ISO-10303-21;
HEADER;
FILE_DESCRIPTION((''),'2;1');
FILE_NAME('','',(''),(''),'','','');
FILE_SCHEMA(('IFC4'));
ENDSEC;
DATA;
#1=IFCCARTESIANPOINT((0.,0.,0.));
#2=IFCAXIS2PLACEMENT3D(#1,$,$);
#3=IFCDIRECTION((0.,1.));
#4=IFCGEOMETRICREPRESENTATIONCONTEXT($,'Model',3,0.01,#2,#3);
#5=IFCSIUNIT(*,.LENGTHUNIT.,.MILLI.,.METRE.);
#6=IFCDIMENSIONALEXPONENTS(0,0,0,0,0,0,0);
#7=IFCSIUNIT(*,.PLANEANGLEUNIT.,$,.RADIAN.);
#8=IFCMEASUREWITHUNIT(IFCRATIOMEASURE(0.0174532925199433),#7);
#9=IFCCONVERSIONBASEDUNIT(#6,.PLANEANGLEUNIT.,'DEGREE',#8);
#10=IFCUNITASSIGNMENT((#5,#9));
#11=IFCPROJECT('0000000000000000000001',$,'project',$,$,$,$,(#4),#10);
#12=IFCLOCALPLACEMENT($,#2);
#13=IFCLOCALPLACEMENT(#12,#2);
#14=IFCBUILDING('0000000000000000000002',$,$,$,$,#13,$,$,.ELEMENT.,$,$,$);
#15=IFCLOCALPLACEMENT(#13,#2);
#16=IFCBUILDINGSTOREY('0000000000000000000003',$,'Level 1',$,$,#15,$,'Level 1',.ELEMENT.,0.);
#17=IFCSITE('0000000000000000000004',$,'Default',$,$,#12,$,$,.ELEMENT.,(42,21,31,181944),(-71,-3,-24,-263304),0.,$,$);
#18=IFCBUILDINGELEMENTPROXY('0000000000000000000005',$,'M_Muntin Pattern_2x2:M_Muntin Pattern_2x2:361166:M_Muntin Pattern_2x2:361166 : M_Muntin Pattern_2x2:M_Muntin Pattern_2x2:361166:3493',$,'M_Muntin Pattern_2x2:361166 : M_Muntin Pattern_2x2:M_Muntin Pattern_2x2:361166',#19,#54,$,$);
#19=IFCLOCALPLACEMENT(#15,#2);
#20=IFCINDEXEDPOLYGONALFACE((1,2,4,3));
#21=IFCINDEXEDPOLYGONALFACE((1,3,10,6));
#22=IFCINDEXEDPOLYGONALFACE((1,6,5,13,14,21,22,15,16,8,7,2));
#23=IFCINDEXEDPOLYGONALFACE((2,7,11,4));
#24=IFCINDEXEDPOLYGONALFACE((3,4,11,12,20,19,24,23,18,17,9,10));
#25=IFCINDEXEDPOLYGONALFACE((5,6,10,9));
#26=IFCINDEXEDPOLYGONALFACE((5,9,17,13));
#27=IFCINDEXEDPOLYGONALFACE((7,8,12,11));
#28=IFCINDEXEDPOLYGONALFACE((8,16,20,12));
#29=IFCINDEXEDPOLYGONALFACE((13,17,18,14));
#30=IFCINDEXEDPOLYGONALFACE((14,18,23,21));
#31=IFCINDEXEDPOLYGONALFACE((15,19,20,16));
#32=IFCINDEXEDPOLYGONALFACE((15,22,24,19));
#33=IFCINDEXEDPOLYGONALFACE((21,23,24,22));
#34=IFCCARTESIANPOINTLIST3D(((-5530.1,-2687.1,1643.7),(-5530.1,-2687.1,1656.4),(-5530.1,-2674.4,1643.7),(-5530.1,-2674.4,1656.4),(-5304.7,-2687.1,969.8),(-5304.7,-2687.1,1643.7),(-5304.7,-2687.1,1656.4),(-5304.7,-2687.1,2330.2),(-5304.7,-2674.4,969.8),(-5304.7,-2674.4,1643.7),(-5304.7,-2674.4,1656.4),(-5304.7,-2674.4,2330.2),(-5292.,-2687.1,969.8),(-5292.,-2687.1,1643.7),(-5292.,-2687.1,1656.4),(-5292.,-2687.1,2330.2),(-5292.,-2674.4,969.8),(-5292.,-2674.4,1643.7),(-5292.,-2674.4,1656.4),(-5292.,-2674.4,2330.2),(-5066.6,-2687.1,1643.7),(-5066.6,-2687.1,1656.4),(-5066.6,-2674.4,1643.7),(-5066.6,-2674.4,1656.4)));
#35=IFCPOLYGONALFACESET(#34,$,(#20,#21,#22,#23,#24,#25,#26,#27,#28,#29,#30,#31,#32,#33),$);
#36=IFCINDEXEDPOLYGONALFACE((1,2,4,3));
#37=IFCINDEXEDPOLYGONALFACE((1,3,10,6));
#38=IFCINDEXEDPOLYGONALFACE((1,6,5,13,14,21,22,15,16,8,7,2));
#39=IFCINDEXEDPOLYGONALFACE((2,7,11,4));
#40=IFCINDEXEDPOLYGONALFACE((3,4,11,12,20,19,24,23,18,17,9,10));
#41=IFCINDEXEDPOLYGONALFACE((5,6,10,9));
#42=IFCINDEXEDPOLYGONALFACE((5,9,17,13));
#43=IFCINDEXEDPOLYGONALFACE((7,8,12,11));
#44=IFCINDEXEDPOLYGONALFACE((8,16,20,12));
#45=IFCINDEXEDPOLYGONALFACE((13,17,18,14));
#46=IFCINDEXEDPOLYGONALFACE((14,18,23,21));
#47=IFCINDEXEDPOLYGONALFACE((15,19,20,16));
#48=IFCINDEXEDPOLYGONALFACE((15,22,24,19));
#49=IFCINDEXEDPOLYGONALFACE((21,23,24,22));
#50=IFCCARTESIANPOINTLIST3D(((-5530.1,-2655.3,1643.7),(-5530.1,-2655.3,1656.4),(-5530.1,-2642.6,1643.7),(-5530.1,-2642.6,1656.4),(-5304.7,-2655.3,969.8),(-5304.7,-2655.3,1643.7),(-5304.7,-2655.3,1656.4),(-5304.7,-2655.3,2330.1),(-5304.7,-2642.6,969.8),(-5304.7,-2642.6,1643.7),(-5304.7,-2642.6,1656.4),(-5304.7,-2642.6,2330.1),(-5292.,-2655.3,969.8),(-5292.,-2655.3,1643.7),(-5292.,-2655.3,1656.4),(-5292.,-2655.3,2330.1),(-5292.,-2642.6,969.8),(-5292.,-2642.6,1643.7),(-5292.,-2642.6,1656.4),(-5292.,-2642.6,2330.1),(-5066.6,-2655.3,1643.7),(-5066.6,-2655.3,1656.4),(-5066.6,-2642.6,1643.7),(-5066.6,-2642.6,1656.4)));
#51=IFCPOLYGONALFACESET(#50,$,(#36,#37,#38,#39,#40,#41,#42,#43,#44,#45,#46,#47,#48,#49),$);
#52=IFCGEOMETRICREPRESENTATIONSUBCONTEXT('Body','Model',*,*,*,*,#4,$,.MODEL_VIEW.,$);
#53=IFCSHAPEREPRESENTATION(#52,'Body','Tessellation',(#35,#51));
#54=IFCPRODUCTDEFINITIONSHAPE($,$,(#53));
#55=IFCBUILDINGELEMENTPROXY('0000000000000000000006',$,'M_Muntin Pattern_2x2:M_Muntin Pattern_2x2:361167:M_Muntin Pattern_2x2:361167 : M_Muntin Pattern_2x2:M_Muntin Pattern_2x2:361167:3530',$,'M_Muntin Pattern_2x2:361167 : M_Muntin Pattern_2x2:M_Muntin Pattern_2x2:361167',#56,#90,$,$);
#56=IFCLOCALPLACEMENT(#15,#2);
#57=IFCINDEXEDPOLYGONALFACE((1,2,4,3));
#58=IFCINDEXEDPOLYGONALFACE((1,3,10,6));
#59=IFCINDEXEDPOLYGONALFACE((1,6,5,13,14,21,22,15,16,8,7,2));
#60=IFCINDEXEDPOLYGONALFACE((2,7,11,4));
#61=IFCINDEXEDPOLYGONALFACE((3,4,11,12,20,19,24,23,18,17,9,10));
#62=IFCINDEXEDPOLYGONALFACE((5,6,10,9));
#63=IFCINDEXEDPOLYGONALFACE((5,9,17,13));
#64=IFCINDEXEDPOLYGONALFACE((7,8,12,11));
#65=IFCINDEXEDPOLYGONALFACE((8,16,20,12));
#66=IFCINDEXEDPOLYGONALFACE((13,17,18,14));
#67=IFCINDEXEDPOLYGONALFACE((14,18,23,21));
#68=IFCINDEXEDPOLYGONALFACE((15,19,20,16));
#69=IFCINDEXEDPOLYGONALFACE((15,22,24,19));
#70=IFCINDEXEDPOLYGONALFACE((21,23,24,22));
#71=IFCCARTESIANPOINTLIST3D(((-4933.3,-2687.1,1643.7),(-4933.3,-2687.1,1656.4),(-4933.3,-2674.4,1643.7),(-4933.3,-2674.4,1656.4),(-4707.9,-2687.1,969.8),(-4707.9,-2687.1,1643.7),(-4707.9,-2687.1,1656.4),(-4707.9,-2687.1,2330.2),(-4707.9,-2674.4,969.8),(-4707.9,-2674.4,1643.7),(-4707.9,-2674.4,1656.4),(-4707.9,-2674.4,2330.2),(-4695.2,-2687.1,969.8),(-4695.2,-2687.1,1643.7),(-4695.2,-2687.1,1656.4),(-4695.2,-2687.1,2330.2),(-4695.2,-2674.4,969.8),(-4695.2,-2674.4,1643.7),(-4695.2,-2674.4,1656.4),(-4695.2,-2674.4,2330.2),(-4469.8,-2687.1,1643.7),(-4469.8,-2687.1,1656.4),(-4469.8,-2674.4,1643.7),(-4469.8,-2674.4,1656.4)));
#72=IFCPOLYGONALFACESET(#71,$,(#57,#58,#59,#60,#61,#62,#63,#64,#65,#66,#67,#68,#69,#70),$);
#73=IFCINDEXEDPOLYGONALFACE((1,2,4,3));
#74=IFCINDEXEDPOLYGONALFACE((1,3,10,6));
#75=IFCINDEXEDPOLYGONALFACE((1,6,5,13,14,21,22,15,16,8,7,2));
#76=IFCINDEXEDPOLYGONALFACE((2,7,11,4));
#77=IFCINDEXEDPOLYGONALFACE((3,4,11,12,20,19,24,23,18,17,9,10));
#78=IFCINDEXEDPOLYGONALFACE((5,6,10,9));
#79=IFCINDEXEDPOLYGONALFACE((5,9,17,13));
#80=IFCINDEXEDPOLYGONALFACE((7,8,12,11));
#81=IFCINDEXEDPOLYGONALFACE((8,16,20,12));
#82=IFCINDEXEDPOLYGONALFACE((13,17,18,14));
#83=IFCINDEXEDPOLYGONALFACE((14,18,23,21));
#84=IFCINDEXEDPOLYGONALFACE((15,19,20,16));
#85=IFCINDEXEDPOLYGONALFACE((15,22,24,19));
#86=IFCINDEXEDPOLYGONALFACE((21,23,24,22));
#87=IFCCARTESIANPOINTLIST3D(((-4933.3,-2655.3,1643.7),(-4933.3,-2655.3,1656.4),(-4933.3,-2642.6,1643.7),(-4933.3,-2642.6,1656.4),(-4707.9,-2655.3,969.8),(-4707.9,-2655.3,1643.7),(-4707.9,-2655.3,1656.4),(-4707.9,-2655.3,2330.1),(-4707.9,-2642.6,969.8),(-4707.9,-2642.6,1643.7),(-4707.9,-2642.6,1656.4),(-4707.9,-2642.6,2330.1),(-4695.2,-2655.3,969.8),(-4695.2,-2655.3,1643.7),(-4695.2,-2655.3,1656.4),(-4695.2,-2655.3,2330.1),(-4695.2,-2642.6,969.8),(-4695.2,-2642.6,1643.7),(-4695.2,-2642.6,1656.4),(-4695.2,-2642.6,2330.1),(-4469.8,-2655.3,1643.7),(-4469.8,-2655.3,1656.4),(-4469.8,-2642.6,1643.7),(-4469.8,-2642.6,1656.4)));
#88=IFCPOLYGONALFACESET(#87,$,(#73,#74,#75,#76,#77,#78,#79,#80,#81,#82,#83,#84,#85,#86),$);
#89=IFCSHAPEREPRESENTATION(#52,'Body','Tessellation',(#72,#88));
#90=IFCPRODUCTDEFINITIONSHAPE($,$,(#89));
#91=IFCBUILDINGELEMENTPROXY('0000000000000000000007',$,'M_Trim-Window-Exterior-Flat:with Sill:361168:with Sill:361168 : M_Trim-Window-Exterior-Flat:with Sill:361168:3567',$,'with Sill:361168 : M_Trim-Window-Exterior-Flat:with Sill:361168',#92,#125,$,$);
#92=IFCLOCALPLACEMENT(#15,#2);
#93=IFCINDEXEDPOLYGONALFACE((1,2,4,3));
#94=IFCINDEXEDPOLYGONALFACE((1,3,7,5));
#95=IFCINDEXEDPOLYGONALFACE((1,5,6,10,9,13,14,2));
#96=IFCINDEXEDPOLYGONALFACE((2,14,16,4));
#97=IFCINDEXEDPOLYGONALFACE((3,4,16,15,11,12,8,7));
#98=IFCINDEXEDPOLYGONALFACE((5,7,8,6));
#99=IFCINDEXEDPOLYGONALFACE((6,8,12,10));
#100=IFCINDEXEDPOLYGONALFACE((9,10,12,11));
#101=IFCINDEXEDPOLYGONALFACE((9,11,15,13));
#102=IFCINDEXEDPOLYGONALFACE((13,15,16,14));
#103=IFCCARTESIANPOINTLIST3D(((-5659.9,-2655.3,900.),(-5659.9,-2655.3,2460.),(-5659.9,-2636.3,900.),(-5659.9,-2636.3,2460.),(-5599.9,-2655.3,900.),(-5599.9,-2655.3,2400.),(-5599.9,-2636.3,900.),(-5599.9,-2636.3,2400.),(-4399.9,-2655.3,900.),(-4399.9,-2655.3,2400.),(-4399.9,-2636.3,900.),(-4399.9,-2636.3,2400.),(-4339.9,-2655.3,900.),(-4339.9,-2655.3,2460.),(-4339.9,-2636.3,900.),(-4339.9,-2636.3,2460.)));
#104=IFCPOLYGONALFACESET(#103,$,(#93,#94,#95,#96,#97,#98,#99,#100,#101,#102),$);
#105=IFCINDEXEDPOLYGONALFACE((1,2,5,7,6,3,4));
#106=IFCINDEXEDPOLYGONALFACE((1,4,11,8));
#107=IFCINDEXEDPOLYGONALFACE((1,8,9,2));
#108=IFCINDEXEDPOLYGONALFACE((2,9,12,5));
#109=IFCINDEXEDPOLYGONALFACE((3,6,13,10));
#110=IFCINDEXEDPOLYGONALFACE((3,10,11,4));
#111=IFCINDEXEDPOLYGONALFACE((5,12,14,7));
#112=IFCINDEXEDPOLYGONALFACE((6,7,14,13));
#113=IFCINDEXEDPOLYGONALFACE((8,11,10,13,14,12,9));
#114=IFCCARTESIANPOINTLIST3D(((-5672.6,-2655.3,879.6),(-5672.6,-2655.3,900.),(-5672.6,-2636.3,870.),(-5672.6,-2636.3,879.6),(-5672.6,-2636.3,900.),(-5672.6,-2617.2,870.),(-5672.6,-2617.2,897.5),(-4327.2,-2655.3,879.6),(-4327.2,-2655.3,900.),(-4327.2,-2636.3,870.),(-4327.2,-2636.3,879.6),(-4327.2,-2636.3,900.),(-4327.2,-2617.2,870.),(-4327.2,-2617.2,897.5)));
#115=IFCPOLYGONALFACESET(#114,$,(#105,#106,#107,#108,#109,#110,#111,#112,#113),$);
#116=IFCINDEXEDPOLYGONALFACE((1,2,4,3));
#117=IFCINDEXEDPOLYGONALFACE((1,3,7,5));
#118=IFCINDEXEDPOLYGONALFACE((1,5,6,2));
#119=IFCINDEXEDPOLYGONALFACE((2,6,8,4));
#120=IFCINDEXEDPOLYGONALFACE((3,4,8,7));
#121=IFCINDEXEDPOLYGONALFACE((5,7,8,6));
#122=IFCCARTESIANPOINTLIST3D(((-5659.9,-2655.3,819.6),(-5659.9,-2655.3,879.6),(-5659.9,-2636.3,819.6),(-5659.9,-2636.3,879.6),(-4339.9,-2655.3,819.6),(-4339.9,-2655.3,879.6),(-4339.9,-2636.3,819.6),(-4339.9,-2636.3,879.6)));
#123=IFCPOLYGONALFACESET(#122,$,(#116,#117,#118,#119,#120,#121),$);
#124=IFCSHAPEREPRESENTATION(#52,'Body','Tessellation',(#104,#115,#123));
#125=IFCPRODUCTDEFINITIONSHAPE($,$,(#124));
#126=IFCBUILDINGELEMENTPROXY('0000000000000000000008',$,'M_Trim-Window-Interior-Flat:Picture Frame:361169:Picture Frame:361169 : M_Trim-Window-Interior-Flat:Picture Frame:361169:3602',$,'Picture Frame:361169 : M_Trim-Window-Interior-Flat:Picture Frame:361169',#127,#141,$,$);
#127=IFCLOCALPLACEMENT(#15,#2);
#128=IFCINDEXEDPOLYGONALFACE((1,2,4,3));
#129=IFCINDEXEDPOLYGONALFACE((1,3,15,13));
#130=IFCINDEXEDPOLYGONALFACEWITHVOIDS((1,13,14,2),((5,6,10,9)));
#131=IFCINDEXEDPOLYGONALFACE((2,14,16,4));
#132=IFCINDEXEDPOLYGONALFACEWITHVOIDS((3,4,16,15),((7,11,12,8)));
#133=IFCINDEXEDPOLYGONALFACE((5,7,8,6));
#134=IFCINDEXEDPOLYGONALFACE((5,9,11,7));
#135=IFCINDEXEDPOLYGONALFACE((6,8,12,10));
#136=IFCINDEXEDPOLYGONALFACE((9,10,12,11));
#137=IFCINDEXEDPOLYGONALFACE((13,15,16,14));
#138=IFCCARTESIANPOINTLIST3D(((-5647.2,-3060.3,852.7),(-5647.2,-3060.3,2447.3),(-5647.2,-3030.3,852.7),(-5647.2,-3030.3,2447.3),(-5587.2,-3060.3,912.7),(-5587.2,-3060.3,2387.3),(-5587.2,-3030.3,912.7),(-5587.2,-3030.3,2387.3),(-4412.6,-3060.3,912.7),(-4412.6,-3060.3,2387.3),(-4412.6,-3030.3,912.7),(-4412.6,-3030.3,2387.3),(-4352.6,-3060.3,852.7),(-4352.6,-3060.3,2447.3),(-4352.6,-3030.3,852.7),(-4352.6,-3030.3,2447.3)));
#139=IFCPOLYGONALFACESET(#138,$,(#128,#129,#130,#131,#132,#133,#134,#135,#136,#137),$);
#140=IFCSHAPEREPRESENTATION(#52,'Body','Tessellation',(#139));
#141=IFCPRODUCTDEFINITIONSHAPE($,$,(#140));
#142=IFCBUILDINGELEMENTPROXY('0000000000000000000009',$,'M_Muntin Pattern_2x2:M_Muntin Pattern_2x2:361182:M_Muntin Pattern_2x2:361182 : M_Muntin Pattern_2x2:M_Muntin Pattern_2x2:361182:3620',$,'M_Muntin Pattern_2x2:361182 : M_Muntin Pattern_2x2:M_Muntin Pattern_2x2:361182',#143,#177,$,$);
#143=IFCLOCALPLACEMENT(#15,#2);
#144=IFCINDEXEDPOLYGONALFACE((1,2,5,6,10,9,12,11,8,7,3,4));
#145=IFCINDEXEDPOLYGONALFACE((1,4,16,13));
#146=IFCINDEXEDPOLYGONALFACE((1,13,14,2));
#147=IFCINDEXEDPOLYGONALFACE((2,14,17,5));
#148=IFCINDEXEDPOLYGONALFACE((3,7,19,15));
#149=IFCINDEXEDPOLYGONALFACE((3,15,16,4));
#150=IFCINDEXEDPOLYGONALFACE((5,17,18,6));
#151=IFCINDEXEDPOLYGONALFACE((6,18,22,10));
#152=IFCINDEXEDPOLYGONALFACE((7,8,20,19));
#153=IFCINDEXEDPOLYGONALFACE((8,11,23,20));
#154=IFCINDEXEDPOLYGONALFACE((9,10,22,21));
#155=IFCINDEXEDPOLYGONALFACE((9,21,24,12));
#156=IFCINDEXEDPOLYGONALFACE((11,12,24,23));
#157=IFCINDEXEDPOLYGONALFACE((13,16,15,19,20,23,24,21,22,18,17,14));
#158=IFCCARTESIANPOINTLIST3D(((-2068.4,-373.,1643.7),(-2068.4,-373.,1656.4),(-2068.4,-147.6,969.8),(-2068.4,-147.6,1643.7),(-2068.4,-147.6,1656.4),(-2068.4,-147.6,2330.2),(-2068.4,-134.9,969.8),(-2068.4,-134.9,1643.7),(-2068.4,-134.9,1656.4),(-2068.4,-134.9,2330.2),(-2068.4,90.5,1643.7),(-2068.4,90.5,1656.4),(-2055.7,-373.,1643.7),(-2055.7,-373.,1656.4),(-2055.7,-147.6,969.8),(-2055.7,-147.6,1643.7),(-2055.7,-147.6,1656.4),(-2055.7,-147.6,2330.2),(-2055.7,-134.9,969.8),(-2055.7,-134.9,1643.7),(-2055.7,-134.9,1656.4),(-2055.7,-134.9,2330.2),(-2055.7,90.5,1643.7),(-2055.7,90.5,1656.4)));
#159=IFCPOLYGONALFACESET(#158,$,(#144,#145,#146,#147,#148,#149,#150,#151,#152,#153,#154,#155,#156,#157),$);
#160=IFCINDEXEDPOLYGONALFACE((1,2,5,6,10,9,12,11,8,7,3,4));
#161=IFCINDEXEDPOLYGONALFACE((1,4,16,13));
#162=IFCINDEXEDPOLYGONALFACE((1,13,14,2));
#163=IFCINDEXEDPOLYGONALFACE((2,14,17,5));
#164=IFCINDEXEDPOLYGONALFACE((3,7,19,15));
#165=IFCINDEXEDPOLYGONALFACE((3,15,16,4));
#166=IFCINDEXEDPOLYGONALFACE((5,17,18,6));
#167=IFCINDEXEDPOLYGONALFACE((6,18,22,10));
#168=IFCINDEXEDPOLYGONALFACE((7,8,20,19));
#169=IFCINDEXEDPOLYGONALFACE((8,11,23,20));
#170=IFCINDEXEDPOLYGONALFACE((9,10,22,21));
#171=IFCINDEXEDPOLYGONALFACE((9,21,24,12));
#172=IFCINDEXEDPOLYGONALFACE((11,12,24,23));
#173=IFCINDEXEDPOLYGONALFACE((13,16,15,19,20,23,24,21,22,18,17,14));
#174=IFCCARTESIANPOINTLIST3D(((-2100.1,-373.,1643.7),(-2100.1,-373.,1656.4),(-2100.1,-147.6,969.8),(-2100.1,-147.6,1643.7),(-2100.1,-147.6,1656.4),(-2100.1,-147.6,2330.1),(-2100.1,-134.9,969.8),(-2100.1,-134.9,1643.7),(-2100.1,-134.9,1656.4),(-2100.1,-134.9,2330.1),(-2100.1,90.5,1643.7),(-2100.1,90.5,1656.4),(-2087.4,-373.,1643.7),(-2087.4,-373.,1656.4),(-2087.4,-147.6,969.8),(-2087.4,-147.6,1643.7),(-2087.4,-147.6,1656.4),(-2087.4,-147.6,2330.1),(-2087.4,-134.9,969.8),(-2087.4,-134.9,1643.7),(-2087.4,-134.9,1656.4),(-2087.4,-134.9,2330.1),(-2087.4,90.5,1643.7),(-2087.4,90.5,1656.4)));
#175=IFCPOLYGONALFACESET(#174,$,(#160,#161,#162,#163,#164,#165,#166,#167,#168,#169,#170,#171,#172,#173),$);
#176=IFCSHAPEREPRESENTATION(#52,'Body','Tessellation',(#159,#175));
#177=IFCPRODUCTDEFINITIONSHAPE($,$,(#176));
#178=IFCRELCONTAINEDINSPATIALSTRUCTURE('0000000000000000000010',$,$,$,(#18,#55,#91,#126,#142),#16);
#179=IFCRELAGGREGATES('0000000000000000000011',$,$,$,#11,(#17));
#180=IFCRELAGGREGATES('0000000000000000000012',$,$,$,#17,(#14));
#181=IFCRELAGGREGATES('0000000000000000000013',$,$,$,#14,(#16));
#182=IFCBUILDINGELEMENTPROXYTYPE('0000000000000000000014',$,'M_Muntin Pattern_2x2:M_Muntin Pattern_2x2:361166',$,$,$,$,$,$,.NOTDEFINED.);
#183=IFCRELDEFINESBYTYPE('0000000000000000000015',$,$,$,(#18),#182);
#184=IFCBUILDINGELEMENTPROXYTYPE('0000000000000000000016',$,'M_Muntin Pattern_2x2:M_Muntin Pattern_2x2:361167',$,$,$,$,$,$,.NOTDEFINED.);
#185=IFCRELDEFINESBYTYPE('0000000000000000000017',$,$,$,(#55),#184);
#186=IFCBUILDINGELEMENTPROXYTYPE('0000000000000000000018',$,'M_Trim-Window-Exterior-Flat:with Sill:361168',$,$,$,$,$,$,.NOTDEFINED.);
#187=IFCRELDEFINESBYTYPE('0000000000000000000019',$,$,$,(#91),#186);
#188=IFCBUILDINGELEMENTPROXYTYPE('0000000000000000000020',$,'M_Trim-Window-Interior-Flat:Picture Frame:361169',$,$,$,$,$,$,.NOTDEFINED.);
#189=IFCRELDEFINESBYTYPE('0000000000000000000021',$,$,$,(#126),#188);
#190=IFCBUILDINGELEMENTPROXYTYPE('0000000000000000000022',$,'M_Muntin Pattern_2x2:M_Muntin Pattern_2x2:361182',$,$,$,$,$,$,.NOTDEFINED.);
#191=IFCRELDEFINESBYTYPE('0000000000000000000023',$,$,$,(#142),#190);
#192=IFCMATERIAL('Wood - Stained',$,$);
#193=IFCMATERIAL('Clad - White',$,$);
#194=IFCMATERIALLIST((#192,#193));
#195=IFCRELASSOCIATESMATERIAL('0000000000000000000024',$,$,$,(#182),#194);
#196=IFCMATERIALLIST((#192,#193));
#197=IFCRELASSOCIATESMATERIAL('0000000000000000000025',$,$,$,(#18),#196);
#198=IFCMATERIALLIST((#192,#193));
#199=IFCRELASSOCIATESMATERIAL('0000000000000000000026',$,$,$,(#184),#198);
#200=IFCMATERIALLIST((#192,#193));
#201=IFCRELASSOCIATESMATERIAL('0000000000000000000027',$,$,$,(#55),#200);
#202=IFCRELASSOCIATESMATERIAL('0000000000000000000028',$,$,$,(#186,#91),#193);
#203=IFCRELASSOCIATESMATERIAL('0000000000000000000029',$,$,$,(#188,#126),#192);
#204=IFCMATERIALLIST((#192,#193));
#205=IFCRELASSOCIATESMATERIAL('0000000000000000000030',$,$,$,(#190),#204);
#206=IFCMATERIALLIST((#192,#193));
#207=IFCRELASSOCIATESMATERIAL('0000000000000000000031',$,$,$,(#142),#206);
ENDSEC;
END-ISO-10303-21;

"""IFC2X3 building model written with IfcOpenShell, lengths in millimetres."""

from ifc_helpers import new_model, entity, si_unit, converted_unit, direction, frame, frame_2d, origin, place, context, subcontext, project, spatial, polyline, rectangle, outline, extrude, source, transform, mapped, material, material_list, type_object, type_shapes, element, save


model = new_model("IFC2X3")

# Units and contexts
model_context = context("Model", 3, precision=0.01, world=origin(), true_north=direction((0.0, 1.0)))
body_context = subcontext(model_context, "Body", "Model", "MODEL_VIEW")
ifc_project = project(units=[si_unit("LENGTHUNIT", "METRE", prefix="MILLI"), converted_unit("PLANEANGLEUNIT", "DEGREE", entity("IfcRatioMeasure", 0.0174532925199433), si_unit("PLANEANGLEUNIT", "RADIAN"), dimensions=[0, 0, 0, 0, 0, 0, 0])], contexts=[model_context])

# Site, building, storey
site_placement = place(None, origin())
site = spatial("IfcSite", under=ifc_project, at=site_placement, Name="Default", CompositionType="ELEMENT", RefLatitude=(42, 21, 31, 181944), RefLongitude=(-71, -3, -24, -263304), RefElevation=0.0)
building_placement = place(site_placement, origin())
building = spatial("IfcBuilding", under=site, at=building_placement, CompositionType="ELEMENT")
storey_placement = place(building_placement, origin())
storey = spatial("IfcBuildingStorey", under=building, at=storey_placement, Name="Level 1", LongName="Level 1", CompositionType="ELEMENT", Elevation=0.0)

# Building element proxies
ifc_material_1 = material(Name="Wood - Stained")
ifc_material_2 = material(Name="Clad - White")
ifc_material_list_1 = material_list([ifc_material_1, ifc_material_2])
ifc_material_list_2 = material_list([ifc_material_1, ifc_material_2])
building_element_proxy_type_1 = type_object("IfcBuildingElementProxyType", Name="M_Muntin Pattern_2x2:M_Muntin Pattern_2x2:361166", PredefinedType="NOTDEFINED", material=ifc_material_list_2)
shared_shape_1 = source(origin(), body_context, "Body", "SweptSolid", [
    extrude(outline(polyline([(-6.4, -680.2), (6.3, -680.2), (6.3, -6.4), (231.7, -6.4), (231.7, 6.3), (6.3, 6.3), (6.3, 680.2), (-6.4, 680.2), (-6.4, 6.3), (-231.7, 6.3), (-231.7, -6.4), (-6.4, -6.4), (-6.4, -680.2)])), frame((-5298.4, -2687.1, 1650.0), z_axis=(0.0, 1.0, 0.0), x_axis=(1.0, 0.0, 0.0)), (0.0, 0.0, 1.0), 12.7),
    extrude(outline(polyline([(-6.4, -680.1), (6.3, -680.1), (6.3, -6.4), (231.7, -6.4), (231.7, 6.3), (6.3, 6.3), (6.3, 680.2), (-6.4, 680.2), (-6.4, 6.3), (-231.7, 6.3), (-231.7, -6.4), (-6.4, -6.4), (-6.4, -680.1)])), frame((-5298.4, -2655.3, 1650.0), z_axis=(0.0, 1.0, 0.0), x_axis=(1.0, 0.0, 0.0)), (0.0, 0.0, 1.0), 12.7),
])
type_shapes(building_element_proxy_type_1, [shared_shape_1])
proxy_1_placement = place(storey_placement, origin())
element("IfcBuildingElementProxy", 1, at=proxy_1_placement, inside=storey, type_object=building_element_proxy_type_1, material=ifc_material_list_1, Name="M_Muntin Pattern_2x2:M_Muntin Pattern_2x2:361166:M_Muntin Pattern_2x2:361166 : M_Muntin Pattern_2x2:M_Muntin Pattern_2x2:361166:3493", ObjectType="M_Muntin Pattern_2x2:361166 : M_Muntin Pattern_2x2:M_Muntin Pattern_2x2:361166", context=body_context, shape_type="MappedRepresentation", body=[
    mapped(shared_shape_1, transform((0.0, 0.0, 0.0), scale=1.0)),
])
ifc_material_list_3 = material_list([ifc_material_1, ifc_material_2])
ifc_material_list_4 = material_list([ifc_material_1, ifc_material_2])
building_element_proxy_type_2 = type_object("IfcBuildingElementProxyType", Name="M_Muntin Pattern_2x2:M_Muntin Pattern_2x2:361167", PredefinedType="NOTDEFINED", material=ifc_material_list_4)
shared_shape_2 = source(origin(), body_context, "Body", "SweptSolid", [
    extrude(outline(polyline([(-680.1, 6.4), (-680.1, -6.3), (-6.4, -6.3), (-6.4, -231.7), (6.3, -231.7), (6.3, -6.3), (680.2, -6.3), (680.2, 6.4), (6.3, 6.4), (6.3, 231.7), (-6.4, 231.7), (-6.4, 6.4), (-680.1, 6.4)])), frame((-4701.5, -2687.1, 1650.0), z_axis=(0.0, -1.0, 0.0), x_axis=(0.0, 0.0, -1.0)), (0.0, 0.0, -1.0), 12.7),
    extrude(outline(polyline([(-680.1, 6.4), (-680.1, -6.3), (-6.4, -6.3), (-6.4, -231.7), (6.3, -231.7), (6.3, -6.3), (680.2, -6.3), (680.2, 6.4), (6.3, 6.4), (6.3, 231.7), (-6.4, 231.7), (-6.4, 6.4), (-680.1, 6.4)])), frame((-4701.5, -2655.3, 1650.0), z_axis=(0.0, -1.0, 0.0), x_axis=(0.0, 0.0, -1.0)), (0.0, 0.0, -1.0), 12.7),
])
type_shapes(building_element_proxy_type_2, [shared_shape_2])
proxy_2_placement = place(storey_placement, origin())
element("IfcBuildingElementProxy", 2, at=proxy_2_placement, inside=storey, type_object=building_element_proxy_type_2, material=ifc_material_list_3, Name="M_Muntin Pattern_2x2:M_Muntin Pattern_2x2:361167:M_Muntin Pattern_2x2:361167 : M_Muntin Pattern_2x2:M_Muntin Pattern_2x2:361167:3530", ObjectType="M_Muntin Pattern_2x2:361167 : M_Muntin Pattern_2x2:M_Muntin Pattern_2x2:361167", context=body_context, shape_type="MappedRepresentation", body=[
    mapped(shared_shape_2, transform((0.0, 0.0, 0.0), scale=1.0)),
])
building_element_proxy_type_3 = type_object("IfcBuildingElementProxyType", Name="M_Trim-Window-Exterior-Flat:with Sill:361168", PredefinedType="NOTDEFINED", material=ifc_material_2)
shared_shape_3 = source(origin(), body_context, "Body", "SweptSolid", [
    extrude(outline(polyline([(-660.0, -765.0), (-600.0, -765.0), (-600.0, 735.0), (600.0, 735.0), (600.0, -765.0), (660.0, -765.0), (660.0, 795.0), (-660.0, 795.0), (-660.0, -765.0)])), frame((-4999.9, -2655.3, 1665.0), z_axis=(0.0, 1.0, 0.0), x_axis=(-1.0, 0.0, 0.0)), (0.0, 0.0, 1.0), 19.1),
    extrude(outline(polyline([(0.0, -15.2), (19.0, -15.2), (19.0, 12.3), (0.0, 14.8), (-19.0, 14.8), (-19.0, -5.7), (0.0, -5.7), (0.0, -15.2)])), frame((-5672.6, -2636.3, 885.2), z_axis=(1.0, 0.0, 0.0), x_axis=(0.0, 1.0, 0.0)), (0.0, 0.0, 1.0), 1345.4),
    extrude(rectangle(XDim=19.1, YDim=1320.0, at=frame_2d((0.0, 0.0), x_axis=(1.0, 0.0))), frame((-4999.9, -2645.8, 819.6), z_axis=(0.0, 0.0, 1.0), x_axis=(0.0, -1.0, 0.0)), (0.0, 0.0, 1.0), 60.0),
])
type_shapes(building_element_proxy_type_3, [shared_shape_3])
proxy_3_placement = place(storey_placement, origin())
element("IfcBuildingElementProxy", 3, at=proxy_3_placement, inside=storey, type_object=building_element_proxy_type_3, material=ifc_material_2, Name="M_Trim-Window-Exterior-Flat:with Sill:361168:with Sill:361168 : M_Trim-Window-Exterior-Flat:with Sill:361168:3567", ObjectType="with Sill:361168 : M_Trim-Window-Exterior-Flat:with Sill:361168", context=body_context, shape_type="MappedRepresentation", body=[
    mapped(shared_shape_3, transform((0.0, 0.0, 0.0), scale=1.0)),
])
building_element_proxy_type_4 = type_object("IfcBuildingElementProxyType", Name="M_Trim-Window-Interior-Flat:Picture Frame:361169", PredefinedType="NOTDEFINED", material=ifc_material_1)
shared_shape_4 = source(origin(), body_context, "Body", "SweptSolid", [
    extrude(outline(polyline([(-647.3, -797.3), (647.3, -797.3), (647.3, 797.3), (-647.3, 797.3), (-647.3, -797.3)]), holes=[polyline([(587.3, 737.3), (587.3, -737.3), (-587.3, -737.3), (-587.3, 737.3), (587.3, 737.3)])]), frame((-4999.9, -3060.3, 1650.0), z_axis=(0.0, 1.0, 0.0), x_axis=(1.0, 0.0, 0.0)), (0.0, 0.0, 1.0), 30.0),
])
type_shapes(building_element_proxy_type_4, [shared_shape_4])
proxy_4_placement = place(storey_placement, origin())
element("IfcBuildingElementProxy", 4, at=proxy_4_placement, inside=storey, type_object=building_element_proxy_type_4, material=ifc_material_1, Name="M_Trim-Window-Interior-Flat:Picture Frame:361169:Picture Frame:361169 : M_Trim-Window-Interior-Flat:Picture Frame:361169:3602", ObjectType="Picture Frame:361169 : M_Trim-Window-Interior-Flat:Picture Frame:361169", context=body_context, shape_type="MappedRepresentation", body=[
    mapped(shared_shape_4, transform((0.0, 0.0, 0.0), scale=1.0)),
])
ifc_material_list_5 = material_list([ifc_material_1, ifc_material_2])
ifc_material_list_6 = material_list([ifc_material_1, ifc_material_2])
building_element_proxy_type_5 = type_object("IfcBuildingElementProxyType", Name="M_Muntin Pattern_2x2:M_Muntin Pattern_2x2:361182", PredefinedType="NOTDEFINED", material=ifc_material_list_6)
shared_shape_5 = source(origin(), body_context, "Body", "SweptSolid", [
    extrude(outline(polyline([(-680.2, 6.4), (-680.2, -6.3), (-6.4, -6.3), (-6.4, -231.7), (6.3, -231.7), (6.3, -6.3), (680.2, -6.3), (680.2, 6.4), (6.3, 6.4), (6.3, 231.7), (-6.4, 231.7), (-6.4, 6.4), (-680.2, 6.4)])), frame((-2068.4, -141.3, 1650.0), z_axis=(-1.0, 0.0, 0.0), x_axis=(0.0, 0.0, -1.0)), (0.0, 0.0, -1.0), 12.7),
    extrude(outline(polyline([(-680.1, 6.4), (-680.1, -6.3), (-6.4, -6.3), (-6.4, -231.7), (6.3, -231.7), (6.3, -6.3), (680.2, -6.3), (680.2, 6.4), (6.3, 6.4), (6.3, 231.7), (-6.4, 231.7), (-6.4, 6.4), (-680.1, 6.4)])), frame((-2100.1, -141.3, 1650.0), z_axis=(-1.0, 0.0, 0.0), x_axis=(0.0, 0.0, -1.0)), (0.0, 0.0, -1.0), 12.7),
])
type_shapes(building_element_proxy_type_5, [shared_shape_5])
proxy_5_placement = place(storey_placement, origin())
element("IfcBuildingElementProxy", 5, at=proxy_5_placement, inside=storey, type_object=building_element_proxy_type_5, material=ifc_material_list_5, Name="M_Muntin Pattern_2x2:M_Muntin Pattern_2x2:361182:M_Muntin Pattern_2x2:361182 : M_Muntin Pattern_2x2:M_Muntin Pattern_2x2:361182:3620", ObjectType="M_Muntin Pattern_2x2:361182 : M_Muntin Pattern_2x2:M_Muntin Pattern_2x2:361182", context=body_context, shape_type="MappedRepresentation", body=[
    mapped(shared_shape_5, transform((0.0, 0.0, 0.0), scale=1.0)),
])

save(model, "model.ifc")
